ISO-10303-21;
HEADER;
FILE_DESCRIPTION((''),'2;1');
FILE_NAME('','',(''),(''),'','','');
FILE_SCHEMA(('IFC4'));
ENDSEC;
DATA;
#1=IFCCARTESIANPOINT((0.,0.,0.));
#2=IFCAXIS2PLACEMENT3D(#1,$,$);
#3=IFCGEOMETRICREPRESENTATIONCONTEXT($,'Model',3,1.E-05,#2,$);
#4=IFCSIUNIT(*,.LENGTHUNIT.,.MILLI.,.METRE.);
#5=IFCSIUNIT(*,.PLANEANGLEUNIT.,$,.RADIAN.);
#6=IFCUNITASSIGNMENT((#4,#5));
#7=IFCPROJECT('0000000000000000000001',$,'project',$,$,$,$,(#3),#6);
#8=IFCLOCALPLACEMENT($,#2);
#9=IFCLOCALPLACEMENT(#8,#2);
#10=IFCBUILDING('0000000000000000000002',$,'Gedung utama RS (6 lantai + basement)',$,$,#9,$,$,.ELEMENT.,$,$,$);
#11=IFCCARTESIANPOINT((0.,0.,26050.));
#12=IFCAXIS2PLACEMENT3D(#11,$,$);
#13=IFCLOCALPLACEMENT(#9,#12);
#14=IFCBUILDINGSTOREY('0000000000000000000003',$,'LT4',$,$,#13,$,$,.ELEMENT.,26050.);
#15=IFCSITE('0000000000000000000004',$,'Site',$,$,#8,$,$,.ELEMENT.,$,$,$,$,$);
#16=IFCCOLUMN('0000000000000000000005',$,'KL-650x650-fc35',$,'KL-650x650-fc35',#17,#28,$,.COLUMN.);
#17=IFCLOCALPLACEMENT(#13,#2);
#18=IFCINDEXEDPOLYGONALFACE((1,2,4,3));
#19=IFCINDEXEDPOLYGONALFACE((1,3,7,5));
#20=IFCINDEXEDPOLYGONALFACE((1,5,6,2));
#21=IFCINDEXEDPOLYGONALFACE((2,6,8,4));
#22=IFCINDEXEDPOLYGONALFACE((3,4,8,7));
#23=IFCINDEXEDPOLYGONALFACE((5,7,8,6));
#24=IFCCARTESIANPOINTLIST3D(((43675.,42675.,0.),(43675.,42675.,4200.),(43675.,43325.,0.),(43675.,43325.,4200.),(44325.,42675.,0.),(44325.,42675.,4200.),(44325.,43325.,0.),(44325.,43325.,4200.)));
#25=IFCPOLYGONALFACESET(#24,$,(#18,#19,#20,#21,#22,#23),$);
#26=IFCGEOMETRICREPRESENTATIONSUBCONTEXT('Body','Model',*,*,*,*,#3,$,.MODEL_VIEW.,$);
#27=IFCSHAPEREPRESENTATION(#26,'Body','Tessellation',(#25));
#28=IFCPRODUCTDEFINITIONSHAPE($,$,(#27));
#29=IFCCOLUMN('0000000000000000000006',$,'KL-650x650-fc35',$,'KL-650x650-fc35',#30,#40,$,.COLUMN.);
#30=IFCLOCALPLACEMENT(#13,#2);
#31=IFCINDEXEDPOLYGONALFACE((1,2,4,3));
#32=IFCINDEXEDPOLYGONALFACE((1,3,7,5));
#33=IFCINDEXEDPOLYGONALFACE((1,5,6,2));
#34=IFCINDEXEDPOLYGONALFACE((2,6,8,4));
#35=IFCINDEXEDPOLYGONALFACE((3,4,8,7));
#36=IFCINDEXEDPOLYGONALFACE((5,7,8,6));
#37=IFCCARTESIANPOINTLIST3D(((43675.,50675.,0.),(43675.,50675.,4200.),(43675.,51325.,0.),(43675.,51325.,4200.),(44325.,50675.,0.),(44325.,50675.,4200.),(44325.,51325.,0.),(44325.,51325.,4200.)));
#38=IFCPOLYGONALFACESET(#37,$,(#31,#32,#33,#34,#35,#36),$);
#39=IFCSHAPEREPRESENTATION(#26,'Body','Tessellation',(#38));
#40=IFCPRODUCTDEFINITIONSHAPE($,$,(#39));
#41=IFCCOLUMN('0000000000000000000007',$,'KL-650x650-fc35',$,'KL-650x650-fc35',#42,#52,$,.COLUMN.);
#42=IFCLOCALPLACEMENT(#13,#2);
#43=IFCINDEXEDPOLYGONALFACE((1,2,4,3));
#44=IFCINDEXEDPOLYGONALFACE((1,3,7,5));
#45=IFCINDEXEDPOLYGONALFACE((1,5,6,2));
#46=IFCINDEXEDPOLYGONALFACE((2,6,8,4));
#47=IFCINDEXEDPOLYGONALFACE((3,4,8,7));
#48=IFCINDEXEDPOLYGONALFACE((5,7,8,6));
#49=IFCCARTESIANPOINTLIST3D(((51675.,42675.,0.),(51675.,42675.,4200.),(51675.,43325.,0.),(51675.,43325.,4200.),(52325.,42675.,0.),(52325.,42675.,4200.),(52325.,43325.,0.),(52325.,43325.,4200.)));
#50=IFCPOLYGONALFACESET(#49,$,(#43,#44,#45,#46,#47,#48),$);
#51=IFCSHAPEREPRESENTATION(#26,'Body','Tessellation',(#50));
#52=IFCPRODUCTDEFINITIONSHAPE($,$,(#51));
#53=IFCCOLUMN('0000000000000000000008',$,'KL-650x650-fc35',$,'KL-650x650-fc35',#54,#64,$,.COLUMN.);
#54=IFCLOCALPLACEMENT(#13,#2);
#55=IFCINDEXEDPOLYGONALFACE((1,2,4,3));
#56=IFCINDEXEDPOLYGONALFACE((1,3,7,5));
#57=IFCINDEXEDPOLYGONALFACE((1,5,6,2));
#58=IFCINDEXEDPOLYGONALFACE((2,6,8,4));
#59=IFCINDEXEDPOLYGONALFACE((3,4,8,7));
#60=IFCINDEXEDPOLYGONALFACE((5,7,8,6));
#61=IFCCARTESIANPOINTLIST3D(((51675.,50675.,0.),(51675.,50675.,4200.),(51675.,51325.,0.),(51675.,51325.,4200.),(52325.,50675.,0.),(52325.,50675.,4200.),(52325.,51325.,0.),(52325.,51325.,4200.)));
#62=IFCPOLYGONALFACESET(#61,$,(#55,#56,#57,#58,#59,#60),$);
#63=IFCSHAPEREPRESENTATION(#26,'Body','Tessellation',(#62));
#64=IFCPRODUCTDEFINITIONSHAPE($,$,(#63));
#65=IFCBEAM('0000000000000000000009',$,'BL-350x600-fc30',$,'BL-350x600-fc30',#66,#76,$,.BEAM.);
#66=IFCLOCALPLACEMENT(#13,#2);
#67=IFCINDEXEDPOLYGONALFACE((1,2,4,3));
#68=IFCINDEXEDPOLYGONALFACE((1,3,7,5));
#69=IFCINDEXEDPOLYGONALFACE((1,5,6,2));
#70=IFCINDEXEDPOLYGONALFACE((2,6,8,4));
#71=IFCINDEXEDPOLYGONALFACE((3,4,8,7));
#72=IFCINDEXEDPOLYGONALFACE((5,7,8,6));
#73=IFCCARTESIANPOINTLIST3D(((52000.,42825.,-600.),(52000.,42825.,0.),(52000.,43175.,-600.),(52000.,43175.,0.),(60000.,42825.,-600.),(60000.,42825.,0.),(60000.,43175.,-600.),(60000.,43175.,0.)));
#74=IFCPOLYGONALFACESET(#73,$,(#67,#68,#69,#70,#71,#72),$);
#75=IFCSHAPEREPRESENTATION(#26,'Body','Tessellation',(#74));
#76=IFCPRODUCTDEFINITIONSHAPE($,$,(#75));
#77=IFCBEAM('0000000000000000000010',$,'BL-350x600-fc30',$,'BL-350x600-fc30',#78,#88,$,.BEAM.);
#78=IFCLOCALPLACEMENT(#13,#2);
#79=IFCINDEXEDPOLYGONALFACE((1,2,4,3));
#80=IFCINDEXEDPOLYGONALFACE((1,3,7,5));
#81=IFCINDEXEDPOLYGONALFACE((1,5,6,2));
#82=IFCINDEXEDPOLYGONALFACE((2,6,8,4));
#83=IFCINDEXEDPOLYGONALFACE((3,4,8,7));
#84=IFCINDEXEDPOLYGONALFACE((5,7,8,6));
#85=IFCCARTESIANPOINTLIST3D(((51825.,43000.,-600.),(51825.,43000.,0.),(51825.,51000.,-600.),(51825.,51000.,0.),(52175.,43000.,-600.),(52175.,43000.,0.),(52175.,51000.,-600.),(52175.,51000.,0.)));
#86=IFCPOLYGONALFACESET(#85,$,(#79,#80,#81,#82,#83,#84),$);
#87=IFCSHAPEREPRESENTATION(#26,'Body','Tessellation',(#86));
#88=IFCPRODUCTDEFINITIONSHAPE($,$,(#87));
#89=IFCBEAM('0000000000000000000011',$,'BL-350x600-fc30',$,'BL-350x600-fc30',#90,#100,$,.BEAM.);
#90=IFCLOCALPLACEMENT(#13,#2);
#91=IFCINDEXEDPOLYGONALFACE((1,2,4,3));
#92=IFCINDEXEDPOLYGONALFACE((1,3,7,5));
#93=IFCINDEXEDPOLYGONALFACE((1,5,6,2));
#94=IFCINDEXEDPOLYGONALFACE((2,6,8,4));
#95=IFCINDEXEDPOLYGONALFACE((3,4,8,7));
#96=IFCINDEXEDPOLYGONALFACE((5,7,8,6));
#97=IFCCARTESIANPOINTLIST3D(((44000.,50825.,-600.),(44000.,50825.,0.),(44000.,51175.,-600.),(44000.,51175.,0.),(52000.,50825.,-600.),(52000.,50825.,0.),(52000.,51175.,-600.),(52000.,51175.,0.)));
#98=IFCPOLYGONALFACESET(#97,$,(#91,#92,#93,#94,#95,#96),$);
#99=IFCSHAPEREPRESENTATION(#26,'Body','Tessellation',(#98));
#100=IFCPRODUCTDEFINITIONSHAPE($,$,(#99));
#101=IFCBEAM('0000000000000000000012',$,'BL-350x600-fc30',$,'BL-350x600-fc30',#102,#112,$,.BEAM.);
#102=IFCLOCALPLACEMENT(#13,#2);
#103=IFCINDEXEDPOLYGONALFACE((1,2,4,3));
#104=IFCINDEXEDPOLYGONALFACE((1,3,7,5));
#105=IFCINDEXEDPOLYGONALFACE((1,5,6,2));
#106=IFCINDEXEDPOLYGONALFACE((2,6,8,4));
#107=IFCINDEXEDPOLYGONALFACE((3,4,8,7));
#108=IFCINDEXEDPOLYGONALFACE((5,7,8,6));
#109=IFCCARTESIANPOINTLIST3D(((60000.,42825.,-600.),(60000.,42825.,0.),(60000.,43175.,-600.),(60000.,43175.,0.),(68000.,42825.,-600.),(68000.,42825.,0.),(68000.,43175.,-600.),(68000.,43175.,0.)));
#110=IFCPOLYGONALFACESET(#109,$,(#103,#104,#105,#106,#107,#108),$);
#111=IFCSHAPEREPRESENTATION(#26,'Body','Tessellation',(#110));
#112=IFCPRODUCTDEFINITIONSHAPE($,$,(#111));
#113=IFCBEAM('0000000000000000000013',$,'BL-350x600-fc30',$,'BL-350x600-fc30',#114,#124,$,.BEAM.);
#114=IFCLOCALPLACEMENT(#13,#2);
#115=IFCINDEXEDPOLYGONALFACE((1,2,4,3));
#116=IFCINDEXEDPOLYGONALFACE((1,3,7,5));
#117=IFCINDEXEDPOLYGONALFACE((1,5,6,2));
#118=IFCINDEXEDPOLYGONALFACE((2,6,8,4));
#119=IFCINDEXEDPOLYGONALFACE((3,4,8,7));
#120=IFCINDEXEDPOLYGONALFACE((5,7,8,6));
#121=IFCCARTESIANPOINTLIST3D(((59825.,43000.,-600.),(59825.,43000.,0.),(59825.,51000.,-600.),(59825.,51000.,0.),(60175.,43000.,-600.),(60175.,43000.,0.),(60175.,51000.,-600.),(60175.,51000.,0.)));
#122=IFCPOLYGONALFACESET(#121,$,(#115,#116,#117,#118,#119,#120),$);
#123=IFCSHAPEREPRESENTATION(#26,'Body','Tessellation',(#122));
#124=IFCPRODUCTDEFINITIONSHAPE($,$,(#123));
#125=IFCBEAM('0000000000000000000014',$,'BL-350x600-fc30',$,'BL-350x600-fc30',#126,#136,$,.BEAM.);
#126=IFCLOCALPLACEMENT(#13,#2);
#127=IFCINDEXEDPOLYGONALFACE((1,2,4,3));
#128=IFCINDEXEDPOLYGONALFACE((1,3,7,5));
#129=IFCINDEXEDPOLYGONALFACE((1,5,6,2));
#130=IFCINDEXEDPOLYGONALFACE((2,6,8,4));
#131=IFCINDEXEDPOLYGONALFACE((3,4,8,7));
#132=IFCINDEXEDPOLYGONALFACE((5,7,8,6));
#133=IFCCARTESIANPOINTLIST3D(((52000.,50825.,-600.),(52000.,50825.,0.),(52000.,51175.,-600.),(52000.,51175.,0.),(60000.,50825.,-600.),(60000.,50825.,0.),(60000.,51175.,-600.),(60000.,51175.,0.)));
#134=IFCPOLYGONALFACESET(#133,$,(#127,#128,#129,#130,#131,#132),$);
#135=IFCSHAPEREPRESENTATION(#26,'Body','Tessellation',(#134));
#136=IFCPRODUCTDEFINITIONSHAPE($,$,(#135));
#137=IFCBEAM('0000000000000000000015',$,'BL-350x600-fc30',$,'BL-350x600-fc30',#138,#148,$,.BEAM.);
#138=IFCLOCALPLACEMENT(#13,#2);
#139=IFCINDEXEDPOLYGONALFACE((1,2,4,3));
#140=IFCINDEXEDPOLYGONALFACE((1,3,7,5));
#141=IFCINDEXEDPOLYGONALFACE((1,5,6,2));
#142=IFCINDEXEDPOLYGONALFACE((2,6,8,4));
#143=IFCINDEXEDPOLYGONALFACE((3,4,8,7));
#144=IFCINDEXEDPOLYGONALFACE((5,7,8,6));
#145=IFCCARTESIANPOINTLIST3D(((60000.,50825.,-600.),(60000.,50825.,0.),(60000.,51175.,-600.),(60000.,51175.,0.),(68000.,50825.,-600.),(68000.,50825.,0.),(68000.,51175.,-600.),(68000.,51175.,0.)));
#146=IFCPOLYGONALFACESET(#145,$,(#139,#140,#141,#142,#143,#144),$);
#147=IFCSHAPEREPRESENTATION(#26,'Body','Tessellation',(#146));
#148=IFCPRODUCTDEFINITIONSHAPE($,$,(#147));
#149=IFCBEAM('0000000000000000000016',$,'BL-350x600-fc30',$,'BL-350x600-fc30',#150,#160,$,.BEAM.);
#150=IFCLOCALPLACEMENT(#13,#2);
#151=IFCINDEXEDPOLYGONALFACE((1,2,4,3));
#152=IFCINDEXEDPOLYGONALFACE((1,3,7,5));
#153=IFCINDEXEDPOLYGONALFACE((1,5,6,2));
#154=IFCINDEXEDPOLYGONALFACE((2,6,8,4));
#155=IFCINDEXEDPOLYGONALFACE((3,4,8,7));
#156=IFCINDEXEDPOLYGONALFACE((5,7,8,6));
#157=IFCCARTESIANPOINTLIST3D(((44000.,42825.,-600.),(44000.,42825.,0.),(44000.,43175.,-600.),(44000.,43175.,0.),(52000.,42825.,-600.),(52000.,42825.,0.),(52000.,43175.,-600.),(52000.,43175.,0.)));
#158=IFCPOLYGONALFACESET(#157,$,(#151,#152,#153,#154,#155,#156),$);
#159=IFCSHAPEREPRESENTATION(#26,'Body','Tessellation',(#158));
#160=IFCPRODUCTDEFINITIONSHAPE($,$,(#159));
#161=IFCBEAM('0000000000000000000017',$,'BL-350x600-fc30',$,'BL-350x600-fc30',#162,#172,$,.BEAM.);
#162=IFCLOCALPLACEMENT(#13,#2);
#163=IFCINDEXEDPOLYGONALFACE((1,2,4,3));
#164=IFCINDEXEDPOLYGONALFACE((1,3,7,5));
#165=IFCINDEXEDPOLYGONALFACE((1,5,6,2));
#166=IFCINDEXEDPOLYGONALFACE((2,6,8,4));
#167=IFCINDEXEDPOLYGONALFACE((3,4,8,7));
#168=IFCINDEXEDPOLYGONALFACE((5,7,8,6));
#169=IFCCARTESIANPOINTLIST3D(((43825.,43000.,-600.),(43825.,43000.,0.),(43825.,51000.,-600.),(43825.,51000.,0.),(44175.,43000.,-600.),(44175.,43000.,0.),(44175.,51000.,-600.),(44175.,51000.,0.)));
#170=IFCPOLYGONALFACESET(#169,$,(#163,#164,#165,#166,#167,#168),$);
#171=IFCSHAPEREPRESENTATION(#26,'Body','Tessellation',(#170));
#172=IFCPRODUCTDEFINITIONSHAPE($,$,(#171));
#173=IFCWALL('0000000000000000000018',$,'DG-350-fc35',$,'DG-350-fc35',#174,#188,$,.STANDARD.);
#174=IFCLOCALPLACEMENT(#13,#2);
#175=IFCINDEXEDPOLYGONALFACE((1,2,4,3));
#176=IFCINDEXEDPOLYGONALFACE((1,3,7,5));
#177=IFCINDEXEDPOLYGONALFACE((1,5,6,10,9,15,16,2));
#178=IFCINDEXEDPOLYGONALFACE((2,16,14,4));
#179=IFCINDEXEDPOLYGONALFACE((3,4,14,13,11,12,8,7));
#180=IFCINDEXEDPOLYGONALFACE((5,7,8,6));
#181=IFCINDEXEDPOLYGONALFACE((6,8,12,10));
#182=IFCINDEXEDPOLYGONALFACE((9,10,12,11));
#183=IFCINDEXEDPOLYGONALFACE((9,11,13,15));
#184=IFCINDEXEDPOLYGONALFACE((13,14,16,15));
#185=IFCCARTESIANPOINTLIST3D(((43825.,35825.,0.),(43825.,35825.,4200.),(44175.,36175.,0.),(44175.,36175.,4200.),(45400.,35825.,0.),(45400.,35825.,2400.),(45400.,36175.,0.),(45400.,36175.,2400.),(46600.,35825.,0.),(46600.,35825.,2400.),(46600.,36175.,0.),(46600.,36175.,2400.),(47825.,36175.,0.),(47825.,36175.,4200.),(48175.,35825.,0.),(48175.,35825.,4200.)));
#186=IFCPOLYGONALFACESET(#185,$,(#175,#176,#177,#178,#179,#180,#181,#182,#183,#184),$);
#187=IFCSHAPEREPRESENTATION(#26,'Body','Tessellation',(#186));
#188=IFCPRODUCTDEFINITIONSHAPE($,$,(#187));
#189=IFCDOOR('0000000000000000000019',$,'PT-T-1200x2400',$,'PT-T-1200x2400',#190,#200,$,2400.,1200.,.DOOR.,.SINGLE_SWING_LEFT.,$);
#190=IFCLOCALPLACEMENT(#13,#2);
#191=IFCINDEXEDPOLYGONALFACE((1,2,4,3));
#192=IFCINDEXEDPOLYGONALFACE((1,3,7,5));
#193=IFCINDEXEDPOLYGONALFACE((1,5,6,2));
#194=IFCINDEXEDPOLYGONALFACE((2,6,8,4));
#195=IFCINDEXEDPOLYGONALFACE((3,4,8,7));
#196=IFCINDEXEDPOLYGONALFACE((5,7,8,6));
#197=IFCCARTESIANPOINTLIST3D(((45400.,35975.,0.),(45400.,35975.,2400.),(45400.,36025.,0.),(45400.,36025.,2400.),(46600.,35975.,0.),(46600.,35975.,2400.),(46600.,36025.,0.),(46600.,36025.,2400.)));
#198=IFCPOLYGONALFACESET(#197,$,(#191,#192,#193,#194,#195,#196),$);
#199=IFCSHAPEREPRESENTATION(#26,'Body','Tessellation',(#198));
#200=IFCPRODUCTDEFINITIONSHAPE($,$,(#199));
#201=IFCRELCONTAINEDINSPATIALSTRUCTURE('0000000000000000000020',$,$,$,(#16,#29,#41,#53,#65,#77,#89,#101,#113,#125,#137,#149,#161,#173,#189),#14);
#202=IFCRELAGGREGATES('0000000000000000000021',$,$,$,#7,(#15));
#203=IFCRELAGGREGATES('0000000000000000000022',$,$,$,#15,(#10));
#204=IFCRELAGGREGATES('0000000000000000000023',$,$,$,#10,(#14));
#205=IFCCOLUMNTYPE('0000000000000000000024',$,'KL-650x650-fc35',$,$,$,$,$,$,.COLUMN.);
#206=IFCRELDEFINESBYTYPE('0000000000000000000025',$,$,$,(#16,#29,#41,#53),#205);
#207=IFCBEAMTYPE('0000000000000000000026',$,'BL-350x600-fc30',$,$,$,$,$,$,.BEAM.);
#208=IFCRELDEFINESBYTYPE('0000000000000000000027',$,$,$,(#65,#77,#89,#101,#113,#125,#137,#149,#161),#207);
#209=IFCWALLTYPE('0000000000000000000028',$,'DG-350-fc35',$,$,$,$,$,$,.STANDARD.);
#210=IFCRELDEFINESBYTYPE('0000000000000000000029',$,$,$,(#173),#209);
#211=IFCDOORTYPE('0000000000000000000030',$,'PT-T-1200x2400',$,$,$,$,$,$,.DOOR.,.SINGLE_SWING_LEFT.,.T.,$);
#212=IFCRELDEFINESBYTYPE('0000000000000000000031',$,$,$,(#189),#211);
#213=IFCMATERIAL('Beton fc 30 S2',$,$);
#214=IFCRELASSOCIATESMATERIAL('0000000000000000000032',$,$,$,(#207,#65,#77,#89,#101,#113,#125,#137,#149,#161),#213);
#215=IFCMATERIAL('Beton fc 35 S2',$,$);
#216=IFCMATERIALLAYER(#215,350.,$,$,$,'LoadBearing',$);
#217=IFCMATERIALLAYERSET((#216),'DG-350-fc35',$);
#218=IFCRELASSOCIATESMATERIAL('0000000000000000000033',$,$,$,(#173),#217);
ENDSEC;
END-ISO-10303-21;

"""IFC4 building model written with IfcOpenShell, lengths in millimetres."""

from ifc_helpers import new_model, si_unit, frame, frame_2d, origin, origin_2d, place, context, subcontext, project, spatial, polyline, rectangle, outline, extrude, material, layer, layer_set, layer_usage, material_profile, profile_set, profile_usage, type_object, element, fill, save


model = new_model("IFC4")

# Units and contexts
model_context = context("Model", 3, precision=1e-05, world=origin())
body_context = subcontext(model_context, "Body", "Model", "MODEL_VIEW")
ifc_project = project(units=[si_unit("LENGTHUNIT", "METRE", prefix="MILLI"), si_unit("PLANEANGLEUNIT", "RADIAN")], contexts=[model_context])

# Site, building, storey
site_placement = place(None, origin())
site = spatial("IfcSite", under=ifc_project, at=site_placement, Name="Site", CompositionType="ELEMENT")
building_placement = place(site_placement, origin())
building = spatial("IfcBuilding", under=site, at=building_placement, Name="Gedung utama RS (6 lantai + basement)", CompositionType="ELEMENT")
storey_placement = place(building_placement, frame((0.0, 0.0, 26050.0)))
storey = spatial("IfcBuildingStorey", under=building, at=storey_placement, Name="LT4", CompositionType="ELEMENT", Elevation=26050.0)

# Columns
ifc_material_profile_1 = material_profile(None, rectangle(XDim=650.0, YDim=650.0, at=origin_2d()), Name="KL-650x650-fc35")
ifc_profile_set_1 = profile_set([ifc_material_profile_1], Name="KL-650x650-fc35")
ifc_profile_usage_1 = profile_usage(ifc_profile_set_1, cardinal=5)
column_type = type_object("IfcColumnType", Name="KL-650x650-fc35", PredefinedType="COLUMN", material=ifc_profile_set_1)
for number, where, z_axis, x_axis, name in (
    (1, (44000.0, 43000.0, 0.0), (0.0, 0.0, 1.0), (1.0, 0.0, 0.0), "KL-650x650-fc35"),
    (2, (44000.0, 51000.0, 0.0), (0.0, 0.0, 1.0), (1.0, 0.0, 0.0), "KL-650x650-fc35"),
    (3, (52000.0, 43000.0, 0.0), (0.0, 0.0, 1.0), (1.0, 0.0, 0.0), "KL-650x650-fc35"),
    (4, (52000.0, 51000.0, 0.0), (0.0, 0.0, 1.0), (1.0, 0.0, 0.0), "KL-650x650-fc35"),
):
    element("IfcColumn", number, at=place(storey_placement, frame(where, z_axis=z_axis, x_axis=x_axis)), inside=storey, type_object=column_type, material=ifc_profile_usage_1, Name=name, ObjectType="KL-650x650-fc35", PredefinedType="COLUMN", context=body_context, shape_type="SweptSolid", body=[
        extrude(rectangle(XDim=650.0, YDim=650.0, at=origin_2d()), origin(), (0.0, 0.0, 1.0), 4200.0),
    ])

# Beams
ifc_material_1 = material(Name="Beton fc 30 S2")
ifc_material_profile_2 = material_profile(ifc_material_1, rectangle(XDim=350.0, YDim=600.0, at=origin_2d()), Name="BL-350x600-fc30")
ifc_profile_set_2 = profile_set([ifc_material_profile_2], Name="BL-350x600-fc30")
ifc_profile_usage_2 = profile_usage(ifc_profile_set_2, cardinal=8)
beam_type = type_object("IfcBeamType", Name="BL-350x600-fc30", PredefinedType="BEAM", material=ifc_profile_set_2)
beam_1_placement = place(storey_placement, frame((52000.0, 43000.0, -300.0)))
element("IfcBeam", 5, at=beam_1_placement, inside=storey, type_object=beam_type, material=ifc_profile_usage_2, Name="BL-350x600-fc30", ObjectType="BL-350x600-fc30", PredefinedType="BEAM", context=body_context, shape_type="SweptSolid", body=[
    extrude(rectangle(XDim=350.0, YDim=600.0, at=origin_2d()), frame((0.0, 0.0, 0.0), z_axis=(1.0, 0.0, 0.0), x_axis=(0.0, 1.0, 0.0)), (0.0, 0.0, 1.0), 8000.0),
])
beam_2_placement = place(storey_placement, frame((52000.0, 43000.0, -300.0)))
element("IfcBeam", 6, at=beam_2_placement, inside=storey, type_object=beam_type, material=ifc_profile_usage_2, Name="BL-350x600-fc30", ObjectType="BL-350x600-fc30", PredefinedType="BEAM", context=body_context, shape_type="SweptSolid", body=[
    extrude(rectangle(XDim=350.0, YDim=600.0, at=origin_2d()), frame((0.0, 0.0, 0.0), z_axis=(0.0, 1.0, 0.0), x_axis=(-1.0, 0.0, 0.0)), (0.0, 0.0, 1.0), 8000.0),
])
for number, where, name in (
    (7, (44000.0, 51000.0, -300.0), "BL-350x600-fc30"),
    (8, (60000.0, 43000.0, -300.0), "BL-350x600-fc30"),
):
    element("IfcBeam", number, at=place(storey_placement, frame(where)), inside=storey, type_object=beam_type, material=ifc_profile_usage_2, Name=name, ObjectType="BL-350x600-fc30", PredefinedType="BEAM", context=body_context, shape_type="SweptSolid", body=[
        extrude(rectangle(XDim=350.0, YDim=600.0, at=origin_2d()), frame((0.0, 0.0, 0.0), z_axis=(1.0, 0.0, 0.0), x_axis=(0.0, 1.0, 0.0)), (0.0, 0.0, 1.0), 8000.0),
    ])
beam_3_placement = place(storey_placement, frame((60000.0, 43000.0, -300.0)))
element("IfcBeam", 9, at=beam_3_placement, inside=storey, type_object=beam_type, material=ifc_profile_usage_2, Name="BL-350x600-fc30", ObjectType="BL-350x600-fc30", PredefinedType="BEAM", context=body_context, shape_type="SweptSolid", body=[
    extrude(rectangle(XDim=350.0, YDim=600.0, at=origin_2d()), frame((0.0, 0.0, 0.0), z_axis=(0.0, 1.0, 0.0), x_axis=(-1.0, 0.0, 0.0)), (0.0, 0.0, 1.0), 8000.0),
])
for number, where, name in (
    (10, (52000.0, 51000.0, -300.0), "BL-350x600-fc30"),
    (11, (60000.0, 51000.0, -300.0), "BL-350x600-fc30"),
    (12, (44000.0, 43000.0, -300.0), "BL-350x600-fc30"),
):
    element("IfcBeam", number, at=place(storey_placement, frame(where)), inside=storey, type_object=beam_type, material=ifc_profile_usage_2, Name=name, ObjectType="BL-350x600-fc30", PredefinedType="BEAM", context=body_context, shape_type="SweptSolid", body=[
        extrude(rectangle(XDim=350.0, YDim=600.0, at=origin_2d()), frame((0.0, 0.0, 0.0), z_axis=(1.0, 0.0, 0.0), x_axis=(0.0, 1.0, 0.0)), (0.0, 0.0, 1.0), 8000.0),
    ])
beam_4_placement = place(storey_placement, frame((44000.0, 43000.0, -300.0)))
element("IfcBeam", 13, at=beam_4_placement, inside=storey, type_object=beam_type, material=ifc_profile_usage_2, Name="BL-350x600-fc30", ObjectType="BL-350x600-fc30", PredefinedType="BEAM", context=body_context, shape_type="SweptSolid", body=[
    extrude(rectangle(XDim=350.0, YDim=600.0, at=origin_2d()), frame((0.0, 0.0, 0.0), z_axis=(0.0, 1.0, 0.0), x_axis=(-1.0, 0.0, 0.0)), (0.0, 0.0, 1.0), 8000.0),
])

# Wall, opening, door
ifc_material_2 = material(Name="Beton fc 35 S2")
ifc_layer = layer(ifc_material_2, 350.0, Category="LoadBearing")
ifc_layer_set = layer_set([ifc_layer], Name="DG-350-fc35")
ifc_layer_usage = layer_usage(ifc_layer_set, "AXIS2", "NEGATIVE", 175.0)
wall_type = type_object("IfcWallType", Name="DG-350-fc35", PredefinedType="STANDARD")
wall_1_placement = place(storey_placement, frame((44000.0, 36000.0, 0.0), z_axis=(0.0, 0.0, 1.0), x_axis=(1.0, 0.0, 0.0)))
wall_1 = element("IfcWall", 14, at=wall_1_placement, inside=storey, type_object=wall_type, material=ifc_layer_usage, Name="DG-350-fc35", ObjectType="DG-350-fc35", PredefinedType="STANDARD", context=body_context, shape_type="SweptSolid", body=[
    extrude(outline(polyline([(-175.0, -175.0), (0.0, 0.0), (175.0, 175.0), (3825.0, 175.0), (4000.0, 0.0), (4175.0, -175.0), (-175.0, -175.0)])), origin(), (0.0, 0.0, 1.0), 4200.0),
])
opening_placement = place(wall_1_placement, frame((1400.0, 0.0, 0.0), z_axis=(0.0, 0.0, 1.0), x_axis=(1.0, 0.0, 0.0)))
opening = element("IfcOpeningElement", 15, at=opening_placement, cuts=wall_1, PredefinedType="OPENING", context=body_context, shape_type="SweptSolid", body=[
    extrude(rectangle(XDim=1200.0, YDim=370.0, at=frame_2d((600.0, 0.0))), origin(), (0.0, 0.0, 1.0), 2400.0),
])
door_type = type_object("IfcDoorType", Name="PT-T-1200x2400", OperationType="SINGLE_SWING_LEFT", ParameterTakesPrecedence=True, PredefinedType="DOOR")
door_placement = place(opening_placement, origin())
door = element("IfcDoor", 16, at=door_placement, inside=storey, type_object=door_type, Name="PT-T-1200x2400", ObjectType="PT-T-1200x2400", OperationType="SINGLE_SWING_LEFT", OverallHeight=2400.0, OverallWidth=1200.0, PredefinedType="DOOR", context=body_context, shape_type="SweptSolid", body=[
    extrude(rectangle(XDim=1200.0, YDim=50.0, at=frame_2d((600.0, 0.0))), origin(), (0.0, 0.0, 1.0), 2400.0),
])
fill(opening, door)

save(model, "model.ifc")
